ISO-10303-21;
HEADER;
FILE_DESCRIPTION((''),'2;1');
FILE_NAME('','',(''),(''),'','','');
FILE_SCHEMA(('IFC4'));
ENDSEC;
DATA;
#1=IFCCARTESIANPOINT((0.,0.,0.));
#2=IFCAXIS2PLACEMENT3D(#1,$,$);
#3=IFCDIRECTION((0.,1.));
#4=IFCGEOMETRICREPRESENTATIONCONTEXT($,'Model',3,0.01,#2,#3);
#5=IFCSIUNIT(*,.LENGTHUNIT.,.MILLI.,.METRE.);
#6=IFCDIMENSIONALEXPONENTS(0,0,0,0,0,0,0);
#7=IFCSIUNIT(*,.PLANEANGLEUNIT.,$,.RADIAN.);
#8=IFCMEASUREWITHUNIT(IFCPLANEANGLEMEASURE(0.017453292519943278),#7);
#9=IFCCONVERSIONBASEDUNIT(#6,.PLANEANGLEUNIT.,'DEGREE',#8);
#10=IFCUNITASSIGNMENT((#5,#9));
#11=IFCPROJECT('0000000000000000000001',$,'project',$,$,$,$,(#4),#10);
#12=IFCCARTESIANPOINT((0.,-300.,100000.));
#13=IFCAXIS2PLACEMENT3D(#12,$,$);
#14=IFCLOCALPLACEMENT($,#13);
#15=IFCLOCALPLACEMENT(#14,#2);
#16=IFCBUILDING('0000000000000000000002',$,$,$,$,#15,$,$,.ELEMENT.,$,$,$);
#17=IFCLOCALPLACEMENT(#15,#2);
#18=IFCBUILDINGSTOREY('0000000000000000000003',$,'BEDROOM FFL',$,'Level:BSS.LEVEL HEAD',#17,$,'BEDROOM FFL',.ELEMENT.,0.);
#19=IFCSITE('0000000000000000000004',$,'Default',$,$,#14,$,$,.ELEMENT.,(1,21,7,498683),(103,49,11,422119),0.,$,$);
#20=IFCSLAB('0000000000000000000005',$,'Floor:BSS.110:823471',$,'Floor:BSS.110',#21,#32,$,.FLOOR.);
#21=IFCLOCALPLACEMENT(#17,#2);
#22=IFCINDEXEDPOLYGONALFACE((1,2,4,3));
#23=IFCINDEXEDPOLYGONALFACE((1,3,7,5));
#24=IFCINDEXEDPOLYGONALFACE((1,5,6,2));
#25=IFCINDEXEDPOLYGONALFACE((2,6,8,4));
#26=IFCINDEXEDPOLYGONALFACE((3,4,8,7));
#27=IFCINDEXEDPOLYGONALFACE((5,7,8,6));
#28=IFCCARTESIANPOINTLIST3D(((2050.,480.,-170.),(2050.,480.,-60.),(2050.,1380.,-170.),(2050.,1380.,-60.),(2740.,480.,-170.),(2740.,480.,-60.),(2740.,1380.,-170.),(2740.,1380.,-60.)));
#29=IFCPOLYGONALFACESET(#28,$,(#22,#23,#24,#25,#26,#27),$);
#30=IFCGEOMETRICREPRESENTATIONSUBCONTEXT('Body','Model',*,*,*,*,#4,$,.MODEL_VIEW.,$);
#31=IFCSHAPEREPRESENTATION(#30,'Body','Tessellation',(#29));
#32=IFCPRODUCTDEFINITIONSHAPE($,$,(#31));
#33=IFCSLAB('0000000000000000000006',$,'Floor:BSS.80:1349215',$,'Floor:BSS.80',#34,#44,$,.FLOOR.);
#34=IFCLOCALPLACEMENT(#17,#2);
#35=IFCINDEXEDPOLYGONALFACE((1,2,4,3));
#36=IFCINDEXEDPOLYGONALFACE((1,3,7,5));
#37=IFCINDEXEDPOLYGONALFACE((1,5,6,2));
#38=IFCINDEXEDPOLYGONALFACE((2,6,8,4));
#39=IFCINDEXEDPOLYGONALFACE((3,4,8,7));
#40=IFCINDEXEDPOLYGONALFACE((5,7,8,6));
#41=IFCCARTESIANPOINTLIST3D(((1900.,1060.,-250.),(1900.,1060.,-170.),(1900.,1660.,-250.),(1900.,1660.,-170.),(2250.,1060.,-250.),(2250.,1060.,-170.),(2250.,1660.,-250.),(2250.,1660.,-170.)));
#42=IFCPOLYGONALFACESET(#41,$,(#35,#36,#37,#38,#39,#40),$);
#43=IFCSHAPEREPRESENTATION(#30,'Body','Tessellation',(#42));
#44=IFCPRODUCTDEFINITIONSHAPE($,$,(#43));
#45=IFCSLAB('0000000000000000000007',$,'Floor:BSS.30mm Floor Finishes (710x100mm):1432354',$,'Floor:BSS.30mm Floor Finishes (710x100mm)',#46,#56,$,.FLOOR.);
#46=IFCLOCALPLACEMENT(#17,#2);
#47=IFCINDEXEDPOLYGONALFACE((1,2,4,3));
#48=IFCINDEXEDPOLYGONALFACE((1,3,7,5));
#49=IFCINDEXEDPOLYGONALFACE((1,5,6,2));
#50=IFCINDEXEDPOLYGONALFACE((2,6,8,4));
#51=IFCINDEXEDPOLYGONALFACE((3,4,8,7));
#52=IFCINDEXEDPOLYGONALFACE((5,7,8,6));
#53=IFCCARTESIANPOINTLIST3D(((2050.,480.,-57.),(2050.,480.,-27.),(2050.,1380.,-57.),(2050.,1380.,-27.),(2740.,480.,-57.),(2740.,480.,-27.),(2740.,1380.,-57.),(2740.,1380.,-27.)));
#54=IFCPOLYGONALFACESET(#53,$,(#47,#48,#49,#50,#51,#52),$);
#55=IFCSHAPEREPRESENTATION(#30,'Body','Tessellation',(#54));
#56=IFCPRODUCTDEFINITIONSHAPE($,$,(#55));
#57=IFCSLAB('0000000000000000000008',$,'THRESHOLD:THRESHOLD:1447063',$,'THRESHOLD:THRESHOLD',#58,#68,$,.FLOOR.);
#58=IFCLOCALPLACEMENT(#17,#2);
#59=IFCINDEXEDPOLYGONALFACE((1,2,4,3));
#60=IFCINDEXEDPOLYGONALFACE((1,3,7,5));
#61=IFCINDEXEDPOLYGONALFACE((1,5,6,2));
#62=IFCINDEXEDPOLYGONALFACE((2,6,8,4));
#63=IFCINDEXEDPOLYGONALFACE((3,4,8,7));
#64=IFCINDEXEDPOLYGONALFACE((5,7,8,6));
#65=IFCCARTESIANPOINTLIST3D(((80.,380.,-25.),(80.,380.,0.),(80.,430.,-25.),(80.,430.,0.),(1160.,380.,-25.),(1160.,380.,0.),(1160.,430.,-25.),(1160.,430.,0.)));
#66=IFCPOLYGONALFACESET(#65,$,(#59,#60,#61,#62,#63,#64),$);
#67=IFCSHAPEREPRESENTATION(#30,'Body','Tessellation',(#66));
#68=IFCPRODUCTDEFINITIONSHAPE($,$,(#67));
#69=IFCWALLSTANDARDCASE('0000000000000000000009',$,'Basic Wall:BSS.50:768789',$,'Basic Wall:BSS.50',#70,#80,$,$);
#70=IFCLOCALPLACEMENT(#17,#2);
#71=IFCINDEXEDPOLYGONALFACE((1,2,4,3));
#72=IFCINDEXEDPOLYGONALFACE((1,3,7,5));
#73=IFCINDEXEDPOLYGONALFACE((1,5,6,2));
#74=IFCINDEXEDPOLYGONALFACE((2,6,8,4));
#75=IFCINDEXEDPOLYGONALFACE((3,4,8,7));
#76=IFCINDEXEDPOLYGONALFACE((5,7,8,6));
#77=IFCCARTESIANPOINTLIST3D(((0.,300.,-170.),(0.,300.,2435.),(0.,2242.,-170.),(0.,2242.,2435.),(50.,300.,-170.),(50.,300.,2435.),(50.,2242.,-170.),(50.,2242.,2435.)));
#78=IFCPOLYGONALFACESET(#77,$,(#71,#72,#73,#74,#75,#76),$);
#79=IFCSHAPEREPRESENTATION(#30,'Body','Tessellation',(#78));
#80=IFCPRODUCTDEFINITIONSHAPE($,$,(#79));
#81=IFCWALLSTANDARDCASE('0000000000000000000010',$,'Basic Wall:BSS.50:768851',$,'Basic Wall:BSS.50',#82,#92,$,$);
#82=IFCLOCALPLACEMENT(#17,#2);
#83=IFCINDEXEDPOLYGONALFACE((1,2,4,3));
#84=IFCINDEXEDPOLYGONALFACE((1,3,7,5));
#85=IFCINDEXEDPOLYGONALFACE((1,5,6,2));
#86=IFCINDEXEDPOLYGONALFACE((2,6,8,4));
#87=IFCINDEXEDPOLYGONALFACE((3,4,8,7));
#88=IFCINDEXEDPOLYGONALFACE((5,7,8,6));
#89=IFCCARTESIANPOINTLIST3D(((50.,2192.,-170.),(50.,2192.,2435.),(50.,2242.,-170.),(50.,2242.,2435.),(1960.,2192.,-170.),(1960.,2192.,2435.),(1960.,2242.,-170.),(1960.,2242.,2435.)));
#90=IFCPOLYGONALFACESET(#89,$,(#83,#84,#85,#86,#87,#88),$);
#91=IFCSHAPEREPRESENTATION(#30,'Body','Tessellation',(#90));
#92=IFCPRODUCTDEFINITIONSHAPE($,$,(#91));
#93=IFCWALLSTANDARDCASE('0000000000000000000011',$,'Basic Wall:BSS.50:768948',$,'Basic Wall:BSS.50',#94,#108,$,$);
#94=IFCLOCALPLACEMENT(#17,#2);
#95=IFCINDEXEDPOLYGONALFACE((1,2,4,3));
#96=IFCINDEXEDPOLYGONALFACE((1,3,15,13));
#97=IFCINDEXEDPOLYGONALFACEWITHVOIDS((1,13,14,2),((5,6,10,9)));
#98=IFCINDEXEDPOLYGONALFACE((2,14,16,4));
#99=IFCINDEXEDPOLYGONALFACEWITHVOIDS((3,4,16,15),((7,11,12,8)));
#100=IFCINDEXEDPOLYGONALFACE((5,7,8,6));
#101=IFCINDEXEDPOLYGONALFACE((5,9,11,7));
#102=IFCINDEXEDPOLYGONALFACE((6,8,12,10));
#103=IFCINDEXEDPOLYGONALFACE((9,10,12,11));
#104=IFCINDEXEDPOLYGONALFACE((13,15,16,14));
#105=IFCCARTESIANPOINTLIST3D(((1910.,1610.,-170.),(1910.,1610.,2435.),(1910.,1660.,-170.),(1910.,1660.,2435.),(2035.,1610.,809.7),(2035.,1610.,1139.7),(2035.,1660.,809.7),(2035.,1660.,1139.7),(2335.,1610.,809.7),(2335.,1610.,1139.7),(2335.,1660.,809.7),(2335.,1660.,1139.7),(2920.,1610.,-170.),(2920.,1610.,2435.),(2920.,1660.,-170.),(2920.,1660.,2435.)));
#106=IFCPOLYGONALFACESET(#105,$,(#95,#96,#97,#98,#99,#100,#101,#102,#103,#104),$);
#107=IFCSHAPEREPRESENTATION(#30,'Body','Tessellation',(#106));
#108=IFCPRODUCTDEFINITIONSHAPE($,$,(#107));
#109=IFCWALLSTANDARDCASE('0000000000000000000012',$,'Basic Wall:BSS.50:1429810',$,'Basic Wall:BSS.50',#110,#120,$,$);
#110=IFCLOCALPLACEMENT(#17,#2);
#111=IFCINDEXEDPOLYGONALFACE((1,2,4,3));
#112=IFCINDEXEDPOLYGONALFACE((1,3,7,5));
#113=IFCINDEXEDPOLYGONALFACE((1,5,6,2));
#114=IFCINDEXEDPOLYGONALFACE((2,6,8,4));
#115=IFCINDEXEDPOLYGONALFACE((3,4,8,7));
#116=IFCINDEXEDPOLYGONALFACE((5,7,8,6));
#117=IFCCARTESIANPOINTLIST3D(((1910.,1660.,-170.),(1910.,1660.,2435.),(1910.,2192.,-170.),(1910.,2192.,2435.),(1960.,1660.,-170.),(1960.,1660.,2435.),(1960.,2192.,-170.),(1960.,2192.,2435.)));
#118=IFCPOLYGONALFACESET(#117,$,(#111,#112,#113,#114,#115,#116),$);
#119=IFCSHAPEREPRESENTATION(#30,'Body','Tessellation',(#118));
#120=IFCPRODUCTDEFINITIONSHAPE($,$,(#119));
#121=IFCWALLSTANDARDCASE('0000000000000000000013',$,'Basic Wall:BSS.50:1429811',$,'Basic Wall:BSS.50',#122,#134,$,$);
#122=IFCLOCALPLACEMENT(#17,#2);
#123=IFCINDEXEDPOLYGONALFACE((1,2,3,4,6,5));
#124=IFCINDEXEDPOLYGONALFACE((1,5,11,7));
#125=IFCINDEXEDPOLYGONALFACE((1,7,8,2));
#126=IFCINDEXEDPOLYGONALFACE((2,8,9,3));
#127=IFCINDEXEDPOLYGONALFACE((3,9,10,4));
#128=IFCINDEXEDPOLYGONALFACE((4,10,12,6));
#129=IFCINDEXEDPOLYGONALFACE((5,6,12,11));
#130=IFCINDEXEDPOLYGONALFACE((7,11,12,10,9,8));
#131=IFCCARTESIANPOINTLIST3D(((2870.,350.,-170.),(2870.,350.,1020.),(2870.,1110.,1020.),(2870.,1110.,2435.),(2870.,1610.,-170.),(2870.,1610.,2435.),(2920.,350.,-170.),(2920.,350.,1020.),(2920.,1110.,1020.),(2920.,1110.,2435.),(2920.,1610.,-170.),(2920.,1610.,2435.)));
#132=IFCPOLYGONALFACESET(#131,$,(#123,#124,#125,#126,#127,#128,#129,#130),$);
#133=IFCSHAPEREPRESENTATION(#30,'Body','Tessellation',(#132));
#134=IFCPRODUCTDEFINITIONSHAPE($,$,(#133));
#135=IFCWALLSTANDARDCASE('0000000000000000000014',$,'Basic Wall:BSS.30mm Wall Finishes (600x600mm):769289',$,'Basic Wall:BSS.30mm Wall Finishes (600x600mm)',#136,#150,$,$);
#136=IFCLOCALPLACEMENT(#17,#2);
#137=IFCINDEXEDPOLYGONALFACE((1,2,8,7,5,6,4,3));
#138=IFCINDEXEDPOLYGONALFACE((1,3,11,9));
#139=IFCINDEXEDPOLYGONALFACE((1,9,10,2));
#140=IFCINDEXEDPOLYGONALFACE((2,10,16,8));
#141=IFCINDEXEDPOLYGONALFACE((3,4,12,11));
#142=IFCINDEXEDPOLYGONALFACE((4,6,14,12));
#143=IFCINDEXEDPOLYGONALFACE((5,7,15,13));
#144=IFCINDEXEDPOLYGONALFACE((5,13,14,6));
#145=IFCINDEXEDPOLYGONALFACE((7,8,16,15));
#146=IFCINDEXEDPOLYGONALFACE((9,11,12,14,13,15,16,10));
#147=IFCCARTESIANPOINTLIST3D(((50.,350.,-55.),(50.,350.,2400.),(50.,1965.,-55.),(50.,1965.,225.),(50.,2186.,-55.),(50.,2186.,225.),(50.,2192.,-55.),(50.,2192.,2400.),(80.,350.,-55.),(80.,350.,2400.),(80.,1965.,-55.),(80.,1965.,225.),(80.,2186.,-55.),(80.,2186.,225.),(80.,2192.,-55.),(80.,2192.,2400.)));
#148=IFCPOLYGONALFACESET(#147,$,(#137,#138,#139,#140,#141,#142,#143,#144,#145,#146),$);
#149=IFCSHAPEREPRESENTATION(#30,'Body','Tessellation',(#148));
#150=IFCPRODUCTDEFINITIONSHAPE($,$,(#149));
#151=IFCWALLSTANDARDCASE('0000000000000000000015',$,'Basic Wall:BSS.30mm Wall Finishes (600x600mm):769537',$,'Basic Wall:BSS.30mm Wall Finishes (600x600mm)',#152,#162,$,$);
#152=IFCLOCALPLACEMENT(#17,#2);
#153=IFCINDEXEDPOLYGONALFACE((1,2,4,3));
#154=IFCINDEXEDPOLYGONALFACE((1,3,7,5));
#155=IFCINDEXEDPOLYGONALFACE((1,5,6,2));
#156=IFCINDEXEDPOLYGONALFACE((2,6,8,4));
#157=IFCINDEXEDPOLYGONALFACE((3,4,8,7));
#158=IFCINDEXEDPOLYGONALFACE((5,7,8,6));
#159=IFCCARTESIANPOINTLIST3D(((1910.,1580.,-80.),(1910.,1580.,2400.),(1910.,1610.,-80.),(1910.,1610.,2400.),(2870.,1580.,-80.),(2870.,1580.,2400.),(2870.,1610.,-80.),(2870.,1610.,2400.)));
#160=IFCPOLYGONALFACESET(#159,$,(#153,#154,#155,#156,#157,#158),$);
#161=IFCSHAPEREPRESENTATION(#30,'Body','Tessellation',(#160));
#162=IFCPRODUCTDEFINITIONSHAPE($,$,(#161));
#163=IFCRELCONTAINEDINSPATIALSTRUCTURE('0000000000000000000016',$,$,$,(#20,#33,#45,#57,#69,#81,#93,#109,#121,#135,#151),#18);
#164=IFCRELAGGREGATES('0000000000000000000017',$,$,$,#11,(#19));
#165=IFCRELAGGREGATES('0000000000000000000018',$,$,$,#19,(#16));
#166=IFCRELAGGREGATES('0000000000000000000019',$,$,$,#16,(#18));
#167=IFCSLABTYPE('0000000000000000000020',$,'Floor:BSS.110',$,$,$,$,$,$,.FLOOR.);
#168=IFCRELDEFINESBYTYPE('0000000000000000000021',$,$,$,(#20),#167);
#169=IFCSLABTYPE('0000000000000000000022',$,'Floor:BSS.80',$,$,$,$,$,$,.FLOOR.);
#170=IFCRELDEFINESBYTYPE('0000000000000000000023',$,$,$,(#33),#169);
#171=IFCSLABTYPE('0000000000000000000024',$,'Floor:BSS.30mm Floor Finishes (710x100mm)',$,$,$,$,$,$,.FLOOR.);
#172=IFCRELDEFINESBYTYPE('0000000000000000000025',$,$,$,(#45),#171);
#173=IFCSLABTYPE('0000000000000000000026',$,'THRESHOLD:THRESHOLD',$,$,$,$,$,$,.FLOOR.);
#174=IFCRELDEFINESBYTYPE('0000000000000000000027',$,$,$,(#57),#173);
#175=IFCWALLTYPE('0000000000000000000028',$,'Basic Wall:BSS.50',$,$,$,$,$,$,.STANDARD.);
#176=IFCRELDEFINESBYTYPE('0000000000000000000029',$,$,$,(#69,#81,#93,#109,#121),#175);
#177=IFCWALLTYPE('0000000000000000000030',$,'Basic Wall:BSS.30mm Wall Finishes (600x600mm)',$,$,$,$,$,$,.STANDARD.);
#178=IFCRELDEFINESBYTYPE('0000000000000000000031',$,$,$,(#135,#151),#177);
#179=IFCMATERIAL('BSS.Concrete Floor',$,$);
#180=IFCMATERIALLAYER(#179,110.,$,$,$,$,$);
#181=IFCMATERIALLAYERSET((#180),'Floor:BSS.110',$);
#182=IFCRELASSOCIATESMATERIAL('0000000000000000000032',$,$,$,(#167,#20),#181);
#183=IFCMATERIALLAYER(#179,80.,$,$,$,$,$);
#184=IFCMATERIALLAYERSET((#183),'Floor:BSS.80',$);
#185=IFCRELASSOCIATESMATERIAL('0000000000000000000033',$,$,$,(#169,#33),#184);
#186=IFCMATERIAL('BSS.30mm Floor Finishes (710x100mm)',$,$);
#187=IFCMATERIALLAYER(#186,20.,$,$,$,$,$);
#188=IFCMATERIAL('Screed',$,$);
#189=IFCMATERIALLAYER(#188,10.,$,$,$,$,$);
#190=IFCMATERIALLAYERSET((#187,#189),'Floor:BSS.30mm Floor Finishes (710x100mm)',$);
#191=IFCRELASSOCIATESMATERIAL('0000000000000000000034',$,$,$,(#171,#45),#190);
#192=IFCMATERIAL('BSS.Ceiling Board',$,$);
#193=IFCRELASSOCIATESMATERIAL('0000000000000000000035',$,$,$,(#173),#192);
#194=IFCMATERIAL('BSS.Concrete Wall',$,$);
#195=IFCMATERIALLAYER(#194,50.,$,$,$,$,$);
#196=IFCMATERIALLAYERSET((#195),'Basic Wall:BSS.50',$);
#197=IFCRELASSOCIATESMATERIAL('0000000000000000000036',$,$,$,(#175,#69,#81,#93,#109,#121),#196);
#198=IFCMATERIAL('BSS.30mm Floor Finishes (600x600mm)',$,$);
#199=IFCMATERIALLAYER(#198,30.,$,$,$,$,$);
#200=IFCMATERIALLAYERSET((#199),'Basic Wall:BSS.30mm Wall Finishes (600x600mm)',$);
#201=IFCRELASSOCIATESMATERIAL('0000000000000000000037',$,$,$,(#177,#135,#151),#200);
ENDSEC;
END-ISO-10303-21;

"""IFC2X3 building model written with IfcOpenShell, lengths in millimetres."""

from ifc_helpers import new_model, entity, si_unit, converted_unit, direction, frame, frame_2d, origin, place, context, subcontext, project, spatial, rectangle, extrude, material, layer, layer_set, layer_usage, type_object, element, save


model = new_model("IFC2X3")

# Units and contexts
model_context = context("Model", 3, precision=0.01, world=origin(), true_north=direction((0.0, 1.0)))
body_context = subcontext(model_context, "Body", "Model", "MODEL_VIEW")
ifc_project = project(units=[si_unit("LENGTHUNIT", "METRE", prefix="MILLI"), converted_unit("PLANEANGLEUNIT", "DEGREE", entity("IfcPlaneAngleMeasure", 0.017453292519943278), si_unit("PLANEANGLEUNIT", "RADIAN"), dimensions=[0, 0, 0, 0, 0, 0, 0])], contexts=[model_context])

# Site, building, storey
site_placement = place(None, frame((0.0, -300.0, 100000.0)))
site = spatial("IfcSite", under=ifc_project, at=site_placement, Name="Default", CompositionType="ELEMENT", RefLatitude=(1, 21, 7, 498683), RefLongitude=(103, 49, 11, 422119), RefElevation=0.0)
building_placement = place(site_placement, origin())
building = spatial("IfcBuilding", under=site, at=building_placement, CompositionType="ELEMENT")
storey_placement = place(building_placement, origin())
storey = spatial("IfcBuildingStorey", under=building, at=storey_placement, Name="BEDROOM FFL", ObjectType="Level:BSS.LEVEL HEAD", LongName="BEDROOM FFL", CompositionType="ELEMENT", Elevation=0.0)

# Slabs
ifc_material_1 = material(Name="BSS.Concrete Floor")
ifc_material_2 = material(Name="BSS.30mm Floor Finishes (600x600mm)")
ifc_layer_1 = layer(ifc_material_1, 110.0)
ifc_layer_set_1 = layer_set([ifc_layer_1], Name="Floor:BSS.110")
ifc_layer_usage_1 = layer_usage(ifc_layer_set_1, "AXIS3", "POSITIVE", 0.0)
slab_type_1 = type_object("IfcSlabType", Name="Floor:BSS.110", PredefinedType="FLOOR", material=ifc_layer_set_1)
slab_1_placement = place(storey_placement, origin())
element("IfcSlab", 1, at=slab_1_placement, inside=storey, type_object=slab_type_1, material=ifc_layer_usage_1, Name="Floor:BSS.110:823471", ObjectType="Floor:BSS.110", PredefinedType="FLOOR", context=body_context, shape_type="SweptSolid", body=[
    extrude(rectangle(XDim=900.0, YDim=690.0, at=frame_2d((0.0, 0.0), x_axis=(1.0, 0.0))), frame((2395.0, 930.0, -60.0), z_axis=(0.0, 0.0, -1.0), x_axis=(0.0, 1.0, 0.0)), (0.0, 0.0, 1.0), 110.0),
])
ifc_layer_2 = layer(ifc_material_1, 80.0)
ifc_layer_set_2 = layer_set([ifc_layer_2], Name="Floor:BSS.80")
ifc_layer_usage_2 = layer_usage(ifc_layer_set_2, "AXIS3", "POSITIVE", 0.0)
slab_type_2 = type_object("IfcSlabType", Name="Floor:BSS.80", PredefinedType="FLOOR", material=ifc_layer_set_2)
slab_2_placement = place(storey_placement, origin())
element("IfcSlab", 2, at=slab_2_placement, inside=storey, type_object=slab_type_2, material=ifc_layer_usage_2, Name="Floor:BSS.80:1349215", ObjectType="Floor:BSS.80", PredefinedType="FLOOR", context=body_context, shape_type="SweptSolid", body=[
    extrude(rectangle(XDim=600.0, YDim=350.0, at=frame_2d((0.0, 0.0), x_axis=(1.0, 0.0))), frame((2075.0, 1360.0, -170.0), z_axis=(0.0, 0.0, -1.0), x_axis=(0.0, 1.0, 0.0)), (0.0, 0.0, 1.0), 80.0),
])
ifc_material_3 = material(Name="BSS.30mm Floor Finishes (710x100mm)")
ifc_layer_3 = layer(ifc_material_3, 20.0)
ifc_material_4 = material(Name="Screed")
ifc_layer_4 = layer(ifc_material_4, 10.0)
ifc_layer_set_3 = layer_set([ifc_layer_3, ifc_layer_4], Name="Floor:BSS.30mm Floor Finishes (710x100mm)")
ifc_layer_usage_3 = layer_usage(ifc_layer_set_3, "AXIS3", "POSITIVE", 0.0)
slab_type_3 = type_object("IfcSlabType", Name="Floor:BSS.30mm Floor Finishes (710x100mm)", PredefinedType="FLOOR", material=ifc_layer_set_3)
slab_3_placement = place(storey_placement, origin())
element("IfcSlab", 3, at=slab_3_placement, inside=storey, type_object=slab_type_3, material=ifc_layer_usage_3, Name="Floor:BSS.30mm Floor Finishes (710x100mm):1432354", ObjectType="Floor:BSS.30mm Floor Finishes (710x100mm)", PredefinedType="FLOOR", context=body_context, shape_type="SweptSolid", body=[
    extrude(rectangle(XDim=900.0, YDim=690.0, at=frame_2d((0.0, 0.0), x_axis=(1.0, 0.0))), frame((2395.0, 930.0, -27.0), z_axis=(0.0, 0.0, -1.0), x_axis=(0.0, 1.0, 0.0)), (0.0, 0.0, 1.0), 30.0),
])
ifc_material_5 = material(Name="BSS.Ceiling Board")
slab_type_4 = type_object("IfcSlabType", Name="THRESHOLD:THRESHOLD", PredefinedType="FLOOR", material=ifc_material_5)
slab_4_placement = place(storey_placement, origin())
element("IfcSlab", 4, at=slab_4_placement, inside=storey, type_object=slab_type_4, Name="THRESHOLD:THRESHOLD:1447063", ObjectType="THRESHOLD:THRESHOLD", PredefinedType="FLOOR", context=body_context, shape_type="SweptSolid", body=[
    extrude(rectangle(XDim=1080.0, YDim=50.0, at=frame_2d((0.0, 0.0), x_axis=(1.0, 0.0))), frame((620.0, 405.0, -25.0)), (0.0, 0.0, 1.0), 25.0),
])

# Walls
ifc_material_6 = material(Name="BSS.Concrete Wall")
ifc_layer_5 = layer(ifc_material_6, 50.0)
ifc_layer_set_4 = layer_set([ifc_layer_5], Name="Basic Wall:BSS.50")
ifc_layer_usage_4 = layer_usage(ifc_layer_set_4, "AXIS2", "NEGATIVE", 25.0)
wall_type_1 = type_object("IfcWallType", Name="Basic Wall:BSS.50", PredefinedType="STANDARD", material=ifc_layer_set_4)
wall_1_placement = place(storey_placement, frame((25.0, 300.0, -170.0), z_axis=(0.0, 0.0, 1.0), x_axis=(0.0, 1.0, 0.0)))
element("IfcWallStandardCase", 5, at=wall_1_placement, inside=storey, type_object=wall_type_1, material=ifc_layer_usage_4, Name="Basic Wall:BSS.50:768789", ObjectType="Basic Wall:BSS.50", context=body_context, shape_type="SweptSolid", body=[
    extrude(rectangle(XDim=1942.0, YDim=50.0, at=frame_2d((971.0, 0.0), x_axis=(-1.0, 0.0))), origin(), (0.0, 0.0, 1.0), 2605.0),
])
ifc_layer_usage_5 = layer_usage(ifc_layer_set_4, "AXIS2", "POSITIVE", -25.0)
wall_2_placement = place(storey_placement, frame((50.0, 2217.0, -170.0)))
element("IfcWallStandardCase", 6, at=wall_2_placement, inside=storey, type_object=wall_type_1, material=ifc_layer_usage_5, Name="Basic Wall:BSS.50:768851", ObjectType="Basic Wall:BSS.50", context=body_context, shape_type="SweptSolid", body=[
    extrude(rectangle(XDim=1910.0, YDim=50.0, at=frame_2d((955.0, 0.0), x_axis=(-1.0, 0.0))), origin(), (0.0, 0.0, 1.0), 2605.0),
])

# Wall, opening
ifc_layer_usage_6 = layer_usage(ifc_layer_set_4, "AXIS2", "POSITIVE", -25.0)
wall_3_placement = place(storey_placement, frame((1910.0, 1635.0, -170.0)))
wall_3 = element("IfcWallStandardCase", 7, at=wall_3_placement, inside=storey, type_object=wall_type_1, material=ifc_layer_usage_6, Name="Basic Wall:BSS.50:768948", ObjectType="Basic Wall:BSS.50", context=body_context, shape_type="SweptSolid", body=[
    extrude(rectangle(XDim=1010.0, YDim=50.0, at=frame_2d((505.0, 0.0), x_axis=(-1.0, 0.0))), origin(), (0.0, 0.0, 1.0), 2605.0),
])
opening_1_placement = place(wall_3_placement, origin())
element("IfcOpeningElement", 8, at=opening_1_placement, cuts=wall_3, ObjectType="Opening", context=body_context, shape_type="SweptSolid", body=[
    extrude(rectangle(XDim=330.0, YDim=300.0, at=frame_2d((0.0, 0.0), x_axis=(0.0, 1.0))), frame((275.0, 25.0, 1144.7), z_axis=(0.0, -1.0, 0.0), x_axis=(-1.0, 0.0, 0.0)), (0.0, 0.0, 1.0), 50.0),
])

# Wall
ifc_layer_usage_7 = layer_usage(ifc_layer_set_4, "AXIS2", "POSITIVE", -25.0)
wall_4_placement = place(storey_placement, frame((1935.0, 2192.0, -170.0), z_axis=(0.0, 0.0, 1.0), x_axis=(0.0, -1.0, 0.0)))
element("IfcWallStandardCase", 9, at=wall_4_placement, inside=storey, type_object=wall_type_1, material=ifc_layer_usage_7, Name="Basic Wall:BSS.50:1429810", ObjectType="Basic Wall:BSS.50", context=body_context, shape_type="SweptSolid", body=[
    extrude(rectangle(XDim=532.0, YDim=50.0, at=frame_2d((266.0, 0.0), x_axis=(-1.0, 0.0))), origin(), (0.0, 0.0, 1.0), 2605.0),
])

# Walls, openings
ifc_layer_usage_8 = layer_usage(ifc_layer_set_4, "AXIS2", "POSITIVE", -25.0)
wall_5_placement = place(storey_placement, frame((2895.0, 1610.0, -170.0), z_axis=(0.0, 0.0, 1.0), x_axis=(0.0, -1.0, 0.0)))
wall_5 = element("IfcWallStandardCase", 10, at=wall_5_placement, inside=storey, type_object=wall_type_1, material=ifc_layer_usage_8, Name="Basic Wall:BSS.50:1429811", ObjectType="Basic Wall:BSS.50", context=body_context, shape_type="SweptSolid", body=[
    extrude(rectangle(XDim=1260.0, YDim=50.0, at=frame_2d((630.0, 0.0), x_axis=(-1.0, 0.0))), origin(), (0.0, 0.0, 1.0), 2605.0),
])
opening_2_placement = place(wall_5_placement, frame((1610.0, -2895.0, 170.0), z_axis=(0.0, 0.0, 1.0), x_axis=(0.0, 1.0, 0.0)))
element("IfcOpeningElement", 11, at=opening_2_placement, cuts=wall_5, ObjectType="Opening", context=body_context, shape_type="SweptSolid", body=[
    extrude(rectangle(XDim=1415.0, YDim=760.0, at=frame_2d((0.0, 0.0), x_axis=(0.0, 1.0))), frame((1346.0, 730.0, 1727.5), z_axis=(1.0, 0.0, 0.0), x_axis=(0.0, -1.0, 0.0)), (0.0, 0.0, 1.0), 3048.0),
])
ifc_layer_6 = layer(ifc_material_2, 30.0)
ifc_layer_set_5 = layer_set([ifc_layer_6], Name="Basic Wall:BSS.30mm Wall Finishes (600x600mm)")
ifc_layer_usage_9 = layer_usage(ifc_layer_set_5, "AXIS2", "NEGATIVE", 15.0)
wall_type_2 = type_object("IfcWallType", Name="Basic Wall:BSS.30mm Wall Finishes (600x600mm)", PredefinedType="STANDARD", material=ifc_layer_set_5)
wall_6_placement = place(storey_placement, frame((65.0, 350.0, -55.0), z_axis=(0.0, 0.0, 1.0), x_axis=(0.0, 1.0, 0.0)))
wall_6 = element("IfcWallStandardCase", 12, at=wall_6_placement, inside=storey, type_object=wall_type_2, material=ifc_layer_usage_9, Name="Basic Wall:BSS.30mm Wall Finishes (600x600mm):769289", ObjectType="Basic Wall:BSS.30mm Wall Finishes (600x600mm)", context=body_context, shape_type="SweptSolid", body=[
    extrude(rectangle(XDim=1842.0, YDim=30.0, at=frame_2d((921.0, 0.0), x_axis=(-1.0, 0.0))), origin(), (0.0, 0.0, 1.0), 2455.0),
])
opening_3_placement = place(wall_6_placement, origin())
element("IfcOpeningElement", 13, at=opening_3_placement, cuts=wall_6, ObjectType="Opening", context=body_context, shape_type="SweptSolid", body=[
    extrude(rectangle(XDim=280.0, YDim=221.0, at=frame_2d((0.0, 0.0), x_axis=(0.0, 1.0))), frame((1725.5, 15.0, 140.0), z_axis=(0.0, -1.0, 0.0), x_axis=(1.0, 0.0, 0.0)), (0.0, 0.0, 1.0), 30.0),
])

# Wall
ifc_layer_usage_10 = layer_usage(ifc_layer_set_5, "AXIS2", "NEGATIVE", 15.0)
wall_7_placement = place(storey_placement, frame((1910.0, 1595.0, -80.0)))
element("IfcWallStandardCase", 14, at=wall_7_placement, inside=storey, type_object=wall_type_2, material=ifc_layer_usage_10, Name="Basic Wall:BSS.30mm Wall Finishes (600x600mm):769537", ObjectType="Basic Wall:BSS.30mm Wall Finishes (600x600mm)", context=body_context, shape_type="SweptSolid", body=[
    extrude(rectangle(XDim=960.0, YDim=30.0, at=frame_2d((480.0, 0.0), x_axis=(-1.0, 0.0))), origin(), (0.0, 0.0, 1.0), 2480.0),
])

save(model, "model.ifc")
